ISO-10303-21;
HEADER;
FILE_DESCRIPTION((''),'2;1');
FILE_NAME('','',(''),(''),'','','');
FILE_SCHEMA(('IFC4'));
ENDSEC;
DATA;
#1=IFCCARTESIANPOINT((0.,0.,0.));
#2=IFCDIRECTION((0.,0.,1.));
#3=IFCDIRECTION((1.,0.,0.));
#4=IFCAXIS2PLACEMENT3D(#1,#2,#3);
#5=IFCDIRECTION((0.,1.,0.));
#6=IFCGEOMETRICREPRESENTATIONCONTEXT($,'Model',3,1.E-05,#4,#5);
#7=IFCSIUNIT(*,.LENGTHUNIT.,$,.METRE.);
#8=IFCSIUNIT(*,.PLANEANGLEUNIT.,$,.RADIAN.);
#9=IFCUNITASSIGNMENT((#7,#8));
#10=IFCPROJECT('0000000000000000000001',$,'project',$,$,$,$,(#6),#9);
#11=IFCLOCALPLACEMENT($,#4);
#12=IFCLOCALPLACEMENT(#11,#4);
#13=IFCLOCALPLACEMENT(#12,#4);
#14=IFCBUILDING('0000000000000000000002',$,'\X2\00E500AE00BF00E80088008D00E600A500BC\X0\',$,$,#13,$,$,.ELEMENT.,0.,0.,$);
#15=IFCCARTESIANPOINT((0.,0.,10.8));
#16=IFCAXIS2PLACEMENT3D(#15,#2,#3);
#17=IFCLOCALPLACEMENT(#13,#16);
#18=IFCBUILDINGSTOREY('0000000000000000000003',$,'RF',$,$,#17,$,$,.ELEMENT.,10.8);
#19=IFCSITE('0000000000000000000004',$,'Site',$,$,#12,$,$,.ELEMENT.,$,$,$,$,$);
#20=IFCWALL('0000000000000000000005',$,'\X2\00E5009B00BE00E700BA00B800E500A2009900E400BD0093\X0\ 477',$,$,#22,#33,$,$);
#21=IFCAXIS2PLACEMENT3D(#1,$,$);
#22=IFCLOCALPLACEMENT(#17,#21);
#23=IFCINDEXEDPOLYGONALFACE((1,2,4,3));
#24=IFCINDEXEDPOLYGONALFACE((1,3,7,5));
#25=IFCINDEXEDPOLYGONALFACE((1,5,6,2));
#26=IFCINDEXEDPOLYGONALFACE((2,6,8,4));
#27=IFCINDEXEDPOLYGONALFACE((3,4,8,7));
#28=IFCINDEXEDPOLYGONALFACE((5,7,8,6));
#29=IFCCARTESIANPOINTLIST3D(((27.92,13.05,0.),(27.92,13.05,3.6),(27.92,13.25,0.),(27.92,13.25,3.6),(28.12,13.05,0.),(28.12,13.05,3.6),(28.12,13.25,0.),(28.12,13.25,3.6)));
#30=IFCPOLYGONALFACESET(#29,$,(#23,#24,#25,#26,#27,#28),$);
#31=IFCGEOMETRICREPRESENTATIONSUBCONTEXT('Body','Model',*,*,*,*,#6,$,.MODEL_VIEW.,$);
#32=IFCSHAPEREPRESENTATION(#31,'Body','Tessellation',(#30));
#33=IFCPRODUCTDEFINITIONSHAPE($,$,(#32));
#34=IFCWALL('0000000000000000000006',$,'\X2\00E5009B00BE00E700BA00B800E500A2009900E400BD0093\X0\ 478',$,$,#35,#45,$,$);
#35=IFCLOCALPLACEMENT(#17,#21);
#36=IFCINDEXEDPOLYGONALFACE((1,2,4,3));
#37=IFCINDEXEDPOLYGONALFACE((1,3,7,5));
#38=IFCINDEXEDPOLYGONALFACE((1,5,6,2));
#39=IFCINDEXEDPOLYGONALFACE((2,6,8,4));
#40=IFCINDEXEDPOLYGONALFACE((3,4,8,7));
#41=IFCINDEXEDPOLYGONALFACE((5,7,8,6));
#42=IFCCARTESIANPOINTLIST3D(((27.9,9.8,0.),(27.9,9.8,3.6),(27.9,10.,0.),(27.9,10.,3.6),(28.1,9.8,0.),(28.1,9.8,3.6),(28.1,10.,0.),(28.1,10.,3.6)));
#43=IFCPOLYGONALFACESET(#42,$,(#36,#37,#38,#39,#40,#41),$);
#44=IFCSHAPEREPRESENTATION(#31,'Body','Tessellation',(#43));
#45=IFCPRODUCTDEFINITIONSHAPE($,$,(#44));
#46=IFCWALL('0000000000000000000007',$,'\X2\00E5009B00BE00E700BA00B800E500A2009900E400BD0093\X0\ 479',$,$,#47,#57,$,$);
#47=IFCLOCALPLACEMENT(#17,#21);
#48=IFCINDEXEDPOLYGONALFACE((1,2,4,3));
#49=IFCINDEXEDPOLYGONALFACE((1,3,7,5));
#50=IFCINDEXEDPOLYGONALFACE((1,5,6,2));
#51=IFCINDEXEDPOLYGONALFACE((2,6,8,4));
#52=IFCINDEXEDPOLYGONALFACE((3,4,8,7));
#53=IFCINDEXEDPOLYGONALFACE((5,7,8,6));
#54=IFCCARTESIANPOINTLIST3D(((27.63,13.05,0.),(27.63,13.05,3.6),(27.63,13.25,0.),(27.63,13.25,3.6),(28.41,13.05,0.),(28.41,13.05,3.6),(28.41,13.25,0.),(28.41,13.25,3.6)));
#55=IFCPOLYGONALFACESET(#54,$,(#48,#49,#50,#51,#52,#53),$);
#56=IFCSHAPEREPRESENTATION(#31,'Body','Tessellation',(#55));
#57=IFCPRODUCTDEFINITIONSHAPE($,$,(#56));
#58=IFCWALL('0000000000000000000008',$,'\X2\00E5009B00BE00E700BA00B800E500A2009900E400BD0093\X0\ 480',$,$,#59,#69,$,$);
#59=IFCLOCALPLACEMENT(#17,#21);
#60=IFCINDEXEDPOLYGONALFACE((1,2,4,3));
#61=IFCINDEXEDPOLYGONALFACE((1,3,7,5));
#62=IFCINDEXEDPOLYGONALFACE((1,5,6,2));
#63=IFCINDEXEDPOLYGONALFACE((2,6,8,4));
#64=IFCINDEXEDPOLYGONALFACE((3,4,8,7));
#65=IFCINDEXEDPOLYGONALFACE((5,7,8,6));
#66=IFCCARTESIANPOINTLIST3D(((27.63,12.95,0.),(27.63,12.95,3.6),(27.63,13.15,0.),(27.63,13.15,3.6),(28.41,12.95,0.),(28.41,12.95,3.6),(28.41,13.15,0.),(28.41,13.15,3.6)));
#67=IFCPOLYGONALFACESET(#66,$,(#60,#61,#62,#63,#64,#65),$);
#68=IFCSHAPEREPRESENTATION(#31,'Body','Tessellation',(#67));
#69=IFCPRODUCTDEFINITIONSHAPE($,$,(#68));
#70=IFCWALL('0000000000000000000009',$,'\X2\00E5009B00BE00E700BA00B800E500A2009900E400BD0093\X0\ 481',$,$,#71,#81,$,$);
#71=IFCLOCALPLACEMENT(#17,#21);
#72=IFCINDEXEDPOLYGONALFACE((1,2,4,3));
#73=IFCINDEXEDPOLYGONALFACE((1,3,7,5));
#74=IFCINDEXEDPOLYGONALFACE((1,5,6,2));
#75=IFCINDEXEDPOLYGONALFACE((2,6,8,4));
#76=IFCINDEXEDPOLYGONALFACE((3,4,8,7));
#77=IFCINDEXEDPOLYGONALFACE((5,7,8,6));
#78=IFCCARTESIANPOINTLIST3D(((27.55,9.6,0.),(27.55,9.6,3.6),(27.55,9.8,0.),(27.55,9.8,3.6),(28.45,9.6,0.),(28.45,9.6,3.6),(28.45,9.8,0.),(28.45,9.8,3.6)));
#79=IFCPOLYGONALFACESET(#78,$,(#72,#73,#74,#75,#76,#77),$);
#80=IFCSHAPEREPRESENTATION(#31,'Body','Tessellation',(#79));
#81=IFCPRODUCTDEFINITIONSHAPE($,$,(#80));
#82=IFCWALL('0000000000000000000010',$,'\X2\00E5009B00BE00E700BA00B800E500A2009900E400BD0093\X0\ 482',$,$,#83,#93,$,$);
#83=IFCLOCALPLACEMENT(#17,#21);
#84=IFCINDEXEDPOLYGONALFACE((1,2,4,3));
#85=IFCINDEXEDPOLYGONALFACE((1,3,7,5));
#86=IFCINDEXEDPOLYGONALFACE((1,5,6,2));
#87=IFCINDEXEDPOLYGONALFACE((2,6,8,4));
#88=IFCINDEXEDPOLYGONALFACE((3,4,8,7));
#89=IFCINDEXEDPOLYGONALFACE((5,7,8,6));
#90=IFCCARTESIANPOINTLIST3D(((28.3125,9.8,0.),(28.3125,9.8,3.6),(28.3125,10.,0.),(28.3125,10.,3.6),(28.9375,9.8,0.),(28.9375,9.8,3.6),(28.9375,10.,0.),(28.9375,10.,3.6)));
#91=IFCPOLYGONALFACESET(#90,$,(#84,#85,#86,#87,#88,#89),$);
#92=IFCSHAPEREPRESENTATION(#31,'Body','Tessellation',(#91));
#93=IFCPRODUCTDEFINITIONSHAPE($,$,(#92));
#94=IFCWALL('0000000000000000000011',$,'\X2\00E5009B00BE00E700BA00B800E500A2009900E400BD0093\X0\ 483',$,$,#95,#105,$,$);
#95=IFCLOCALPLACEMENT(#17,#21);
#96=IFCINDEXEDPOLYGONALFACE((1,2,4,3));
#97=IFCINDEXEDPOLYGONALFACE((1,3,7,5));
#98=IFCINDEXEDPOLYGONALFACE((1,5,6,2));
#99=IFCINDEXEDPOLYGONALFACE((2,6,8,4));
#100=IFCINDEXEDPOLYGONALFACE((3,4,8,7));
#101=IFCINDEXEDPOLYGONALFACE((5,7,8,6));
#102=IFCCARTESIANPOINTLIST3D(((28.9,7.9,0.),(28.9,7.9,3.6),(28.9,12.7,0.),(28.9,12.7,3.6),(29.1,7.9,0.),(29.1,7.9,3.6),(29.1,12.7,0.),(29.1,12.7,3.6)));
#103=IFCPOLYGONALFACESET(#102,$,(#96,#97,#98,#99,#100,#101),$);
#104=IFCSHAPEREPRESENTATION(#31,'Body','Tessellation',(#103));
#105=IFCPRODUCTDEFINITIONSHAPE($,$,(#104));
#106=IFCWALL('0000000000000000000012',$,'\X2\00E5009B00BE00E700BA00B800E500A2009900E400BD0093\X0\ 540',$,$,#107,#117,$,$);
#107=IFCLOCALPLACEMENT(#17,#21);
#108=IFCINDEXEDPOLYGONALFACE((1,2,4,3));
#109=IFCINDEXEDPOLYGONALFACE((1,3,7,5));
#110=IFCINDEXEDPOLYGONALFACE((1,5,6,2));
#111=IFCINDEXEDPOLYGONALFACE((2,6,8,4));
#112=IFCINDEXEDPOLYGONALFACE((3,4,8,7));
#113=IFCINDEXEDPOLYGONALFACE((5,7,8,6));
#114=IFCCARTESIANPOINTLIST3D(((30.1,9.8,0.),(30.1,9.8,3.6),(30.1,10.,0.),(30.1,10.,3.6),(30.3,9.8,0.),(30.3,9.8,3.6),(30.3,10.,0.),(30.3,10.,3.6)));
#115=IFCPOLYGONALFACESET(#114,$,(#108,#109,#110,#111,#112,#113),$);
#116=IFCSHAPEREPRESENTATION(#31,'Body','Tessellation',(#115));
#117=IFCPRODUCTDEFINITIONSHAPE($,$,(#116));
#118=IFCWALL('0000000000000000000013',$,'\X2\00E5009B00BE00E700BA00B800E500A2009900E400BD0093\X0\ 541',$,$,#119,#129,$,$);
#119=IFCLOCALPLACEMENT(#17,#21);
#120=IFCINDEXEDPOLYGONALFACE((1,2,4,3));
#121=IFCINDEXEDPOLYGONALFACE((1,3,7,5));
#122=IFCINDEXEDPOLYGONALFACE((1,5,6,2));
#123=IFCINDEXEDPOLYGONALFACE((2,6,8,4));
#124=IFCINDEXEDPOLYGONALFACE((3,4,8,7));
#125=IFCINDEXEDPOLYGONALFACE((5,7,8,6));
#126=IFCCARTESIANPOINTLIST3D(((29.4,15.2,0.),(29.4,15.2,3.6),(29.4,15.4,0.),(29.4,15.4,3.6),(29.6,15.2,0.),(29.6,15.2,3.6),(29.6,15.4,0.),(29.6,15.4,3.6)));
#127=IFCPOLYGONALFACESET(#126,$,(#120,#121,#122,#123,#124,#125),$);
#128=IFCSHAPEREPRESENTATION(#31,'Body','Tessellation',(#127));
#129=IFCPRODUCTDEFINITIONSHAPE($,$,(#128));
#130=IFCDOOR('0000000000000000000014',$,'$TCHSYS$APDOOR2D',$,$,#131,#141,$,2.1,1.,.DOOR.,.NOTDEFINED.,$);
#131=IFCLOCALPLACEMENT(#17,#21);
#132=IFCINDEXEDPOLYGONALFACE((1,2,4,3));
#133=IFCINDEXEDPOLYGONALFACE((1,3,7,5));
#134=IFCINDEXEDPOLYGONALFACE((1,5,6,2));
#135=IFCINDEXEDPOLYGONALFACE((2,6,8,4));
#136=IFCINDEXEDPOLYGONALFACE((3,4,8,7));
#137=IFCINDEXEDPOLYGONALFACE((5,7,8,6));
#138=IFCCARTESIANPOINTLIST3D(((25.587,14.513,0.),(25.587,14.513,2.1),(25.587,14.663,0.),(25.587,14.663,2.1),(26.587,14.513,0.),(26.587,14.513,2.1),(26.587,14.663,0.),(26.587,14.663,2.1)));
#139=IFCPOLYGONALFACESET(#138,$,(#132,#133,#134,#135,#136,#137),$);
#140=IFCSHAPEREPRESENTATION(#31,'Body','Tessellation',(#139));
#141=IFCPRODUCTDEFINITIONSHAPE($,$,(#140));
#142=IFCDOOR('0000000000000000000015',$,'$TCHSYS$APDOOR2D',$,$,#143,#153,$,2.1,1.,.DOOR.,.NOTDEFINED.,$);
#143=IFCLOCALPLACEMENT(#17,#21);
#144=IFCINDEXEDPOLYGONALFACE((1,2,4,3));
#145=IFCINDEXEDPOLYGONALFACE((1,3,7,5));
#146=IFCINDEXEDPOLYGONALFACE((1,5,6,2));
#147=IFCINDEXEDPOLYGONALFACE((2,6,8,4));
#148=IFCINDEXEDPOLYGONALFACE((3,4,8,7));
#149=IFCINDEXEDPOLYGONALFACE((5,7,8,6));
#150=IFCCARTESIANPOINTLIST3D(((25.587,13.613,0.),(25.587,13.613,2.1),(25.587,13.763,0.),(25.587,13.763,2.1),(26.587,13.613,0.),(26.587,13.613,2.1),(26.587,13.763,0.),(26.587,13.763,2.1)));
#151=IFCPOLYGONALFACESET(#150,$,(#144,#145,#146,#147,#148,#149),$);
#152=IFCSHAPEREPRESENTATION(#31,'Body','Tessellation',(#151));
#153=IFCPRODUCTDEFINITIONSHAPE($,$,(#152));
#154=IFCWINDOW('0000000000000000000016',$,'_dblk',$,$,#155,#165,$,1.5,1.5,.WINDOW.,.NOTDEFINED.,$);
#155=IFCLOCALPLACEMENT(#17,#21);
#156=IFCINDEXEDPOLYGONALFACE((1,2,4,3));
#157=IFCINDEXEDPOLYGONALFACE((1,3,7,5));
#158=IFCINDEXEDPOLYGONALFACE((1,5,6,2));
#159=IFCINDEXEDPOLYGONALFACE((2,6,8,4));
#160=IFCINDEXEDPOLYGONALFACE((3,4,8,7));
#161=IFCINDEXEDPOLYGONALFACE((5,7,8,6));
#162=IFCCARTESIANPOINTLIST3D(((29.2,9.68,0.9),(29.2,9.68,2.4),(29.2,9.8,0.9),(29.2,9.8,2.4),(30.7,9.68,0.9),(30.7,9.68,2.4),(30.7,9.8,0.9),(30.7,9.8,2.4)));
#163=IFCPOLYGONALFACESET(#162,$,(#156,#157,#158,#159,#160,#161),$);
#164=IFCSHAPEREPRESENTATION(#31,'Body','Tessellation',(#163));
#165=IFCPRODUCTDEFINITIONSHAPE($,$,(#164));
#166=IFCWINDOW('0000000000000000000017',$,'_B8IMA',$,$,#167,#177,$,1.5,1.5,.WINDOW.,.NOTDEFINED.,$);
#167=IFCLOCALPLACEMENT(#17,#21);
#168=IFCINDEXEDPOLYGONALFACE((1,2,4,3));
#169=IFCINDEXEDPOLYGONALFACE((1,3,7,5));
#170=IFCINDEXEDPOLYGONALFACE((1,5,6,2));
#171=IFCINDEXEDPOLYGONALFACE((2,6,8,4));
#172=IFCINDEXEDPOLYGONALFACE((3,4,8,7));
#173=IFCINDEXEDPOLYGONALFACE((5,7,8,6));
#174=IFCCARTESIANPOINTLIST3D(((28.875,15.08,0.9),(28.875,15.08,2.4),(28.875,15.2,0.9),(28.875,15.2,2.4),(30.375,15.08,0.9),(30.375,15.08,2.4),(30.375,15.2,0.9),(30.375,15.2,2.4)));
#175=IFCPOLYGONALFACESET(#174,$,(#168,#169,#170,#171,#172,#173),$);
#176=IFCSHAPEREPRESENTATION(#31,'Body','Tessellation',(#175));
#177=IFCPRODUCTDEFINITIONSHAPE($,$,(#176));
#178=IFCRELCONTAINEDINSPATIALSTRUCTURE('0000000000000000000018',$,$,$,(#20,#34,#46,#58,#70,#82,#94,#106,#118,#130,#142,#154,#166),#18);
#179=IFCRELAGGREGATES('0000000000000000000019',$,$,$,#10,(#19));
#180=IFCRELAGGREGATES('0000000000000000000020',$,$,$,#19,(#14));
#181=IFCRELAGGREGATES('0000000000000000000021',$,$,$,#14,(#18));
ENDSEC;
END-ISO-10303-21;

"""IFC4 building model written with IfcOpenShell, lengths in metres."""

from ifc_helpers import new_model, si_unit, direction, frame, frame_2d, origin_with_axes, place, context, subcontext, project, spatial, rectangle, extrude, element, save


model = new_model("IFC4")

# Units and contexts
model_context = context("Model", 3, precision=1e-05, world=origin_with_axes(), true_north=direction((0.0, 1.0, 0.0)))
body_context = subcontext(model_context, "Body", "Model", "MODEL_VIEW")
ifc_project = project(units=[si_unit("LENGTHUNIT", "METRE"), si_unit("PLANEANGLEUNIT", "RADIAN")], contexts=[model_context])

# Site, building, storey
placement = place(None, origin_with_axes())
site_placement = place(placement, origin_with_axes())
site = spatial("IfcSite", under=ifc_project, at=site_placement, Name="Site", CompositionType="ELEMENT")
building_placement = place(site_placement, origin_with_axes())
building = spatial("IfcBuilding", under=site, at=building_placement, Name="å®¿è\u0088\u008dæ¥¼", CompositionType="ELEMENT", ElevationOfRefHeight=0.0, ElevationOfTerrain=0.0)
storey_placement = place(building_placement, frame((0.0, 0.0, 10.8), z_axis=(0.0, 0.0, 1.0), x_axis=(1.0, 0.0, 0.0)))
storey = spatial("IfcBuildingStorey", under=building, at=storey_placement, Name="RF", CompositionType="ELEMENT", Elevation=10.8)

# Walls
for number, where, z_axis, x_axis, name in (
    (1, (28.02, 13.15, 0.0), (0.0, 0.0, 1.0), (0.0, -1.0, 0.0), "å\u009b¾çº¸å¢\u0099ä½\u0093 477"),
    (2, (28.0, 9.9, 0.0), (0.0, 0.0, 1.0), (0.0, -1.0, 0.0), "å\u009b¾çº¸å¢\u0099ä½\u0093 478"),
):
    element("IfcWall", number, at=place(storey_placement, frame(where, z_axis=z_axis, x_axis=x_axis)), inside=storey, Name=name, context=body_context, shape_type="SweptSolid", body=[
        extrude(rectangle(XDim=0.2, YDim=0.2, at=frame_2d((0.0, 0.0), x_axis=(1.0, 0.0, 0.0))), frame((0.0, 0.0, 0.0), z_axis=(0.0, 0.0, 1.0)), (0.0, 0.0, 1.0), 3.6),
    ])
for number, where, z_axis, x_axis, name in (
    (3, (28.02, 13.15, 0.0), (0.0, 0.0, 1.0), (1.0, 0.0, 0.0), "å\u009b¾çº¸å¢\u0099ä½\u0093 479"),
    (4, (28.02, 13.05, 0.0), (0.0, 0.0, 1.0), (1.0, 0.0, 0.0), "å\u009b¾çº¸å¢\u0099ä½\u0093 480"),
):
    element("IfcWall", number, at=place(storey_placement, frame(where, z_axis=z_axis, x_axis=x_axis)), inside=storey, Name=name, context=body_context, shape_type="SweptSolid", body=[
        extrude(rectangle(XDim=0.78, YDim=0.2, at=frame_2d((0.0, 0.0), x_axis=(1.0, 0.0, 0.0))), frame((0.0, 0.0, 0.0), z_axis=(0.0, 0.0, 1.0)), (0.0, 0.0, 1.0), 3.6),
    ])
wall_1_placement = place(storey_placement, frame((28.0, 9.7, 0.0), z_axis=(0.0, 0.0, 1.0), x_axis=(1.0, 0.0, 0.0)))
element("IfcWall", 5, at=wall_1_placement, inside=storey, Name="å\u009b¾çº¸å¢\u0099ä½\u0093 481", context=body_context, shape_type="SweptSolid", body=[
    extrude(rectangle(XDim=0.9, YDim=0.2, at=frame_2d((0.0, 0.0), x_axis=(1.0, 0.0, 0.0))), frame((0.0, 0.0, 0.0), z_axis=(0.0, 0.0, 1.0)), (0.0, 0.0, 1.0), 3.6),
])
wall_2_placement = place(storey_placement, frame((28.625, 9.9, 0.0), z_axis=(0.0, 0.0, 1.0), x_axis=(-1.0, 0.0, 0.0)))
element("IfcWall", 6, at=wall_2_placement, inside=storey, Name="å\u009b¾çº¸å¢\u0099ä½\u0093 482", context=body_context, shape_type="SweptSolid", body=[
    extrude(rectangle(XDim=0.625, YDim=0.2, at=frame_2d((0.0, 0.0), x_axis=(1.0, 0.0, 0.0))), frame((0.0, 0.0, 0.0), z_axis=(0.0, 0.0, 1.0)), (0.0, 0.0, 1.0), 3.6),
])
wall_3_placement = place(storey_placement, frame((29.0, 10.3, 0.0), z_axis=(0.0, 0.0, 1.0), x_axis=(0.0, 1.0, 0.0)))
element("IfcWall", 7, at=wall_3_placement, inside=storey, Name="å\u009b¾çº¸å¢\u0099ä½\u0093 483", context=body_context, shape_type="SweptSolid", body=[
    extrude(rectangle(XDim=4.8, YDim=0.2, at=frame_2d((0.0, 0.0), x_axis=(1.0, 0.0, 0.0))), frame((0.0, 0.0, 0.0), z_axis=(0.0, 0.0, 1.0)), (0.0, 0.0, 1.0), 3.6),
])
for number, where, z_axis, x_axis, name in (
    (8, (30.2, 9.9, 0.0), (0.0, 0.0, 1.0), (0.0, -1.0, 0.0), "å\u009b¾çº¸å¢\u0099ä½\u0093 540"),
    (9, (29.5, 15.3, 0.0), (0.0, 0.0, 1.0), (0.0, -1.0, 0.0), "å\u009b¾çº¸å¢\u0099ä½\u0093 541"),
):
    element("IfcWall", number, at=place(storey_placement, frame(where, z_axis=z_axis, x_axis=x_axis)), inside=storey, Name=name, context=body_context, shape_type="SweptSolid", body=[
        extrude(rectangle(XDim=0.2, YDim=0.2, at=frame_2d((0.0, 0.0), x_axis=(1.0, 0.0, 0.0))), frame((0.0, 0.0, 0.0), z_axis=(0.0, 0.0, 1.0)), (0.0, 0.0, 1.0), 3.6),
    ])

# Doors
for number, where, z_axis, x_axis, name in (
    (10, (26.087, 14.588, 0.0), (0.0, 0.0, 1.0), (1.0, 0.0, 0.0), "$TCHSYS$APDOOR2D"),
    (11, (26.087, 13.688, 0.0), (0.0, 0.0, 1.0), (1.0, 0.0, 0.0), "$TCHSYS$APDOOR2D"),
):
    element("IfcDoor", number, at=place(storey_placement, frame(where, z_axis=z_axis, x_axis=x_axis)), inside=storey, Name=name, OperationType="NOTDEFINED", OverallHeight=2.1, OverallWidth=1.0, PredefinedType="DOOR", context=body_context, shape_type="SweptSolid", body=[
        extrude(rectangle(XDim=1.0, YDim=0.15, at=frame_2d((0.0, 0.0), x_axis=(1.0, 0.0, 0.0))), frame((0.0, 0.0, 0.0), z_axis=(0.0, 0.0, 1.0)), (0.0, 0.0, 1.0), 2.1),
    ])

# Windows
for number, where, z_axis, x_axis, name in (
    (12, (29.95, 9.74, 0.9), (0.0, 0.0, 1.0), (1.0, 0.0, 0.0), "_dblk"),
    (13, (29.625, 15.14, 0.9), (0.0, 0.0, 1.0), (1.0, 0.0, 0.0), "_B8IMA"),
):
    element("IfcWindow", number, at=place(storey_placement, frame(where, z_axis=z_axis, x_axis=x_axis)), inside=storey, Name=name, OverallHeight=1.5, OverallWidth=1.5, PartitioningType="NOTDEFINED", PredefinedType="WINDOW", context=body_context, shape_type="SweptSolid", body=[
        extrude(rectangle(XDim=1.5, YDim=0.12, at=frame_2d((0.0, 0.0), x_axis=(1.0, 0.0, 0.0))), frame((0.0, 0.0, 0.0), z_axis=(0.0, 0.0, 1.0)), (0.0, 0.0, 1.0), 1.5),
    ])

save(model, "model.ifc")
